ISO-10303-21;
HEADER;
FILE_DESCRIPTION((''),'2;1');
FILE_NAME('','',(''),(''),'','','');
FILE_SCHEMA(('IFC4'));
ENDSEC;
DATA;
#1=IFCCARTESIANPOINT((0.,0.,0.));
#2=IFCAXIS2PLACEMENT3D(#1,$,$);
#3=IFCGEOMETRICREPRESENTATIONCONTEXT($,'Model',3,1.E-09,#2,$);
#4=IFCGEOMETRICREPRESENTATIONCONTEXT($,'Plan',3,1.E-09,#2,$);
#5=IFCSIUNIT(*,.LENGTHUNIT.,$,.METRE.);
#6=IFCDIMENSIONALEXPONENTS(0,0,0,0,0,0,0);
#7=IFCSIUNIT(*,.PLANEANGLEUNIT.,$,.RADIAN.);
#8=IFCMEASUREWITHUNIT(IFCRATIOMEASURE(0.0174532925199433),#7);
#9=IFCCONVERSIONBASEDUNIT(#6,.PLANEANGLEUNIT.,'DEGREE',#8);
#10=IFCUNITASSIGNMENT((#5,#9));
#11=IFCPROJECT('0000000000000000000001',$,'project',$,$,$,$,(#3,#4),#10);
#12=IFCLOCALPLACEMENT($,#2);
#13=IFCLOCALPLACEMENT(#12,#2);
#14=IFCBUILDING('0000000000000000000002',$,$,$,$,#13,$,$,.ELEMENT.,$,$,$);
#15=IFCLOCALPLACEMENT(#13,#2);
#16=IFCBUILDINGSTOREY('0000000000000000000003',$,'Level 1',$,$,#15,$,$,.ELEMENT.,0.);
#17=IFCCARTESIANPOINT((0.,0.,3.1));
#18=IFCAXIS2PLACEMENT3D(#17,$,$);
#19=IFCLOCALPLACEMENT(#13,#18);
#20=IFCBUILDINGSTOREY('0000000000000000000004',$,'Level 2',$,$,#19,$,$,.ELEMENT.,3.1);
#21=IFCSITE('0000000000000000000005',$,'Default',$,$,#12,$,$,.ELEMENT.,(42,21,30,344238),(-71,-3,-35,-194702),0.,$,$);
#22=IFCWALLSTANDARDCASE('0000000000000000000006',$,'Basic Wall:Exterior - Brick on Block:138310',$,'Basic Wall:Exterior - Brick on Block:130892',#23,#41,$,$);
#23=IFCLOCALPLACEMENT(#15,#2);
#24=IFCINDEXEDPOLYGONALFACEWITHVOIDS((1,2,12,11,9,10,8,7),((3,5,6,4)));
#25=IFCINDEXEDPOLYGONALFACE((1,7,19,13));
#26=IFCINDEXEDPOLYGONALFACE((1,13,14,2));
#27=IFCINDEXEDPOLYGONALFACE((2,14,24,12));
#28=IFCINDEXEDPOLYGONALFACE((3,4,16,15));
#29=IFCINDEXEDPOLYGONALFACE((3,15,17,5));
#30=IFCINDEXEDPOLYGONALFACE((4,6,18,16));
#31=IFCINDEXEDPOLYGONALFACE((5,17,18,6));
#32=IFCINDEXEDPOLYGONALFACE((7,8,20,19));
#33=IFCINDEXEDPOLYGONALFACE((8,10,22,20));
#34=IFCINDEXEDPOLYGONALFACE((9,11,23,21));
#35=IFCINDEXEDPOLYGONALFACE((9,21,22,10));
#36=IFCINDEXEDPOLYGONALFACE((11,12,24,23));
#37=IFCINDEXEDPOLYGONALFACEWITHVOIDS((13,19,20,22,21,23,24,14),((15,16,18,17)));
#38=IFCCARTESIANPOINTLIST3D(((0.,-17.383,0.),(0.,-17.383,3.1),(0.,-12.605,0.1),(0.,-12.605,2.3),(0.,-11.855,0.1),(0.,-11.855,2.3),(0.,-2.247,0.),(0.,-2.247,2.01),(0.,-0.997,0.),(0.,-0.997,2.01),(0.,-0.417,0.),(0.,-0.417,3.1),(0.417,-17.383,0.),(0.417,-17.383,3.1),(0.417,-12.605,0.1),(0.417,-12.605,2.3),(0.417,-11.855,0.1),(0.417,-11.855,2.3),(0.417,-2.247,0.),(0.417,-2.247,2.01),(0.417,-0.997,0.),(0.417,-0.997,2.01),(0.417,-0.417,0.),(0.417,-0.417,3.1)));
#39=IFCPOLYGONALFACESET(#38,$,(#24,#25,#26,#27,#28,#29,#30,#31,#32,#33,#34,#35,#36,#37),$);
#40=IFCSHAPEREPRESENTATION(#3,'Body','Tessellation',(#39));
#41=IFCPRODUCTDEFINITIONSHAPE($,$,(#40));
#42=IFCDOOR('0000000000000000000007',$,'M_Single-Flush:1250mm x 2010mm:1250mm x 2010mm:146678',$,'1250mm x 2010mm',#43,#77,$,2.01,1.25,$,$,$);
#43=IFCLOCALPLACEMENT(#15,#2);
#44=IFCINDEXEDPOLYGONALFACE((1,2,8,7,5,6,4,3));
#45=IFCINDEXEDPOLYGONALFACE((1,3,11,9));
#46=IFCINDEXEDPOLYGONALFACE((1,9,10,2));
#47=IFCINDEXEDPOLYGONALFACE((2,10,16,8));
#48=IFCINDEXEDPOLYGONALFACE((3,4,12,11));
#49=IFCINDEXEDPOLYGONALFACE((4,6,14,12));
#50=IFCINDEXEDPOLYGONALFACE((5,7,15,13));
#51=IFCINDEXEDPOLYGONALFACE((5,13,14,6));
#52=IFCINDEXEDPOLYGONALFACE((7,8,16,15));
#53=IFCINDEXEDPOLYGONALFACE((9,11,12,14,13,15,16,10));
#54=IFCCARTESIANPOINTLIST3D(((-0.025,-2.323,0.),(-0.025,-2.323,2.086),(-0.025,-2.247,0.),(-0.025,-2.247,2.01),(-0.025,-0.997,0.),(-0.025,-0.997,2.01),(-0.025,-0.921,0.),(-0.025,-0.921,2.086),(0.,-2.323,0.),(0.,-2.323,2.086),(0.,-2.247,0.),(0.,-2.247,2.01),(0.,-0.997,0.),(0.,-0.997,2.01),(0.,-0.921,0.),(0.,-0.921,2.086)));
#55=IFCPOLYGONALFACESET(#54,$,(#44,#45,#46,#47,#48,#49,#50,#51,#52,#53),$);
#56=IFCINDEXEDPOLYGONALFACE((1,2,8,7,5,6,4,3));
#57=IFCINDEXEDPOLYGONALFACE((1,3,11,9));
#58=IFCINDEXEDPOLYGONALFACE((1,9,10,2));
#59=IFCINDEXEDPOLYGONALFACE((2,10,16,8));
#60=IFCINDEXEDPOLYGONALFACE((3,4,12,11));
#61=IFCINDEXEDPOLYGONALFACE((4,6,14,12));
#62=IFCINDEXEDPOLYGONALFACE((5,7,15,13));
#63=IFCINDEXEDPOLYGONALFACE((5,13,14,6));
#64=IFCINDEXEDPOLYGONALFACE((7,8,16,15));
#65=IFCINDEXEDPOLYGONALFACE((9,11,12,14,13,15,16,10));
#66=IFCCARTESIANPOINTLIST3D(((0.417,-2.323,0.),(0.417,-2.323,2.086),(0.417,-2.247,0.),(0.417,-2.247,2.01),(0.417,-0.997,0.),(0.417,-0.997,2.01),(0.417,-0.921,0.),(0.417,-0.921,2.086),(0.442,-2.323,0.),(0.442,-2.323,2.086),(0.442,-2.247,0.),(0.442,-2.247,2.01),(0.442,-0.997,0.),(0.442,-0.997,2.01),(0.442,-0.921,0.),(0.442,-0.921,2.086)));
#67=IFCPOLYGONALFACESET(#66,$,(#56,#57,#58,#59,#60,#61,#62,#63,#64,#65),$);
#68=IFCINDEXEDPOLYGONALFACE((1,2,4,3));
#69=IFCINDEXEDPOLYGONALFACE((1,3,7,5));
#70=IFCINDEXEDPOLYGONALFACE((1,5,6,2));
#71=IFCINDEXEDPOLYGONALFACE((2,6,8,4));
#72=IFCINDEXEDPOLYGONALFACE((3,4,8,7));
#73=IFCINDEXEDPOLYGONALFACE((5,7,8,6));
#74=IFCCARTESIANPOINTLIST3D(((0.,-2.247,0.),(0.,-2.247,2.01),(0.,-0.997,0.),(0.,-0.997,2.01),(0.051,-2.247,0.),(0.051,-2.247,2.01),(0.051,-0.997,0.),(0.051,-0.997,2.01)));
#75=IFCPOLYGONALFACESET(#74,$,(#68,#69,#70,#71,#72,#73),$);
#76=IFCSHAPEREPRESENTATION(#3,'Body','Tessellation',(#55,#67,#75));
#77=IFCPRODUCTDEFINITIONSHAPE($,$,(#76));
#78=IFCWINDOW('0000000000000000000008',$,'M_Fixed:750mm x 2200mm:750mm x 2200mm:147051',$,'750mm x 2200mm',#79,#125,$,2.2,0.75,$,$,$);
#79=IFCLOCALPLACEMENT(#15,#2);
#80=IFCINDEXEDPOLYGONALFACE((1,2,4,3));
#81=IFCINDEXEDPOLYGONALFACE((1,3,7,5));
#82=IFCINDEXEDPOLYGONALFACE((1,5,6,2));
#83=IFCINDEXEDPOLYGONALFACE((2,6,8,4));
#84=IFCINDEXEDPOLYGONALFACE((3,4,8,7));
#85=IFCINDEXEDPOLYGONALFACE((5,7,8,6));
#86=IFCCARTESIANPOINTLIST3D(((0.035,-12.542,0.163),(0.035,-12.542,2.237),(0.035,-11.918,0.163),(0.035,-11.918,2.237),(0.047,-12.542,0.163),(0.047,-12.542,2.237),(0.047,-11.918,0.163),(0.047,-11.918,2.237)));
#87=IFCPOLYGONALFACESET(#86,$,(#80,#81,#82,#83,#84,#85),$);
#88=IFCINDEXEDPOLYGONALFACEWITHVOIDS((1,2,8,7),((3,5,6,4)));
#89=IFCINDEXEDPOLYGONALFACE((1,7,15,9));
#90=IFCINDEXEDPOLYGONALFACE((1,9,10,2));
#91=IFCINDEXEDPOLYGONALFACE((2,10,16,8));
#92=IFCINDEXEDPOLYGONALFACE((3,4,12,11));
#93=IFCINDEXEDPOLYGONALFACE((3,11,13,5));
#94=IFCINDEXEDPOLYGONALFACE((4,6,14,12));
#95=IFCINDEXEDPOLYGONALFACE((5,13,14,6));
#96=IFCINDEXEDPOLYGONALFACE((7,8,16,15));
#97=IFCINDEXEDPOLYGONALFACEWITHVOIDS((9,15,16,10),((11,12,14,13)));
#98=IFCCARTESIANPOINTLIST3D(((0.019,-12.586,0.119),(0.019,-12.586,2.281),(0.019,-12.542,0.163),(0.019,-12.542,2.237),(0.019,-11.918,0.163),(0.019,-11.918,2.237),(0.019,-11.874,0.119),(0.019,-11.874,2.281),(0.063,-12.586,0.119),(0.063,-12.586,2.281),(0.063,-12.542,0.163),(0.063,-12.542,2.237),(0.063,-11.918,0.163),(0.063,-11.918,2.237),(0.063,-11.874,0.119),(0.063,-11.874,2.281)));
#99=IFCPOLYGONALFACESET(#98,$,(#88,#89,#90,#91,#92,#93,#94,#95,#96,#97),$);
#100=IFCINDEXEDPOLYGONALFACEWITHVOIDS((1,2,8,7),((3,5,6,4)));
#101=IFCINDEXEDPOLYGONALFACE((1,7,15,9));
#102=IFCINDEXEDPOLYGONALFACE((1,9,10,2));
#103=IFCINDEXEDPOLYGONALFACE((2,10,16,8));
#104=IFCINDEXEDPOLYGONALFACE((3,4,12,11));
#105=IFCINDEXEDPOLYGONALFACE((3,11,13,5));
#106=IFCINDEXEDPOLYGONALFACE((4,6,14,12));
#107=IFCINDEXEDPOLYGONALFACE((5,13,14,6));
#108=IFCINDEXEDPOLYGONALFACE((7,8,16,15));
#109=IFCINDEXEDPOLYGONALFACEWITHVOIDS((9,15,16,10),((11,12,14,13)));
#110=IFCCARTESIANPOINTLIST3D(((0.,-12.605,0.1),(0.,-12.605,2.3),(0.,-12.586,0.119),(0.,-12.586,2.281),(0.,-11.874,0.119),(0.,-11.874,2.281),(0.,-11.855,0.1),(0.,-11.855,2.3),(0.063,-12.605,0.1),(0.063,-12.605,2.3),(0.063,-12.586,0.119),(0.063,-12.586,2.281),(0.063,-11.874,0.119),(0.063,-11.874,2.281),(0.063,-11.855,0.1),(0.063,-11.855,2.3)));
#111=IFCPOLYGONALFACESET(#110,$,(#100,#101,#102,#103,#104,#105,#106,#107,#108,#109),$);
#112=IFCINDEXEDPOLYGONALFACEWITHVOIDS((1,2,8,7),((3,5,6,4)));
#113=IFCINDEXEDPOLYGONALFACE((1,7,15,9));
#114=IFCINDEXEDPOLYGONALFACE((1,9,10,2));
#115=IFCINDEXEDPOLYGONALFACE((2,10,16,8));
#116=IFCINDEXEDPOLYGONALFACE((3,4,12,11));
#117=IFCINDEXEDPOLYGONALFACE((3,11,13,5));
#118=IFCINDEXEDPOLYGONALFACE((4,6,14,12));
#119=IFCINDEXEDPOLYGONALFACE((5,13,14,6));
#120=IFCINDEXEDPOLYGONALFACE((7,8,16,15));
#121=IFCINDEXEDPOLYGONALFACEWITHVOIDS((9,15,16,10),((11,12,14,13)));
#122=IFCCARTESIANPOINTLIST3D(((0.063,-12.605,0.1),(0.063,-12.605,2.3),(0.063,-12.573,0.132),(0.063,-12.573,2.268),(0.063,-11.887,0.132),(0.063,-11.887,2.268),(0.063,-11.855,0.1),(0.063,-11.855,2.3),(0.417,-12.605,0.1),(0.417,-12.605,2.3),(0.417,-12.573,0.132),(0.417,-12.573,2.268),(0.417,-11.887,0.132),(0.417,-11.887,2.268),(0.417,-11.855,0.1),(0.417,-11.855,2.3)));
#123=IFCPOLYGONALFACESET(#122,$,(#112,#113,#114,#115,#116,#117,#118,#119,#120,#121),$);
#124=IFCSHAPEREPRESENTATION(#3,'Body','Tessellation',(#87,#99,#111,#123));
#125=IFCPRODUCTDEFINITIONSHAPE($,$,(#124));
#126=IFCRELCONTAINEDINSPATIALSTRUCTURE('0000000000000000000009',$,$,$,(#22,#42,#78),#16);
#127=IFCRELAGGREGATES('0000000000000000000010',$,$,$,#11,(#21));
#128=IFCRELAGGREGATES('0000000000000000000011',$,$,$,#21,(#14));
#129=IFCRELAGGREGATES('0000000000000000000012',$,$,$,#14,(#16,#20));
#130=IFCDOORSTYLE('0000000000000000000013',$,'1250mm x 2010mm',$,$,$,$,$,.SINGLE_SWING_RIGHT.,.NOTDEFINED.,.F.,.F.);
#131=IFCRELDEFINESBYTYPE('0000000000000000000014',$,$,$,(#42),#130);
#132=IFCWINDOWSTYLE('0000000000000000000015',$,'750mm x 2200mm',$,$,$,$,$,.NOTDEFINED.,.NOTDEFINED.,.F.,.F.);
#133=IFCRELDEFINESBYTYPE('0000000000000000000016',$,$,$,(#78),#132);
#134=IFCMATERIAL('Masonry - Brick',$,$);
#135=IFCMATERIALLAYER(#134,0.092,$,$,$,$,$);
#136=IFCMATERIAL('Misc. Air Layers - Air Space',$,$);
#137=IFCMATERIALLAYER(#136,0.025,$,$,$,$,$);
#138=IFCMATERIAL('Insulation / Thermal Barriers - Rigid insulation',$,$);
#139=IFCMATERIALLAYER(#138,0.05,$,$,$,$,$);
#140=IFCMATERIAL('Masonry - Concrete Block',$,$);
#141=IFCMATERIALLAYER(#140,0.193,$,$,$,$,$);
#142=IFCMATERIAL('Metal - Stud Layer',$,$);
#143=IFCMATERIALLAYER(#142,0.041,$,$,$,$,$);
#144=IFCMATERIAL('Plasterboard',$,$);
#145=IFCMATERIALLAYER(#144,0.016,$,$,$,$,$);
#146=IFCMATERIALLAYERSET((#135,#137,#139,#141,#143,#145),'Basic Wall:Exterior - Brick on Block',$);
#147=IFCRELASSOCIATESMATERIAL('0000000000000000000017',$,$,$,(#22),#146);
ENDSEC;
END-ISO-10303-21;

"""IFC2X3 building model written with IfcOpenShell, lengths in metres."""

from ifc_helpers import new_model, entity, si_unit, converted_unit, frame, frame_2d, origin, origin_2d_with_axis, place, context, project, spatial, polyline, rectangle, outline, extrude, source, transform, mapped, material, layer, layer_set, layer_usage, type_object, type_shapes, element, fill, save


model = new_model("IFC2X3")

# Units and contexts
model_context = context("Model", 3, precision=1e-09, world=origin())
plan_context = context("Plan", 3, precision=1e-09, world=origin())
ifc_project = project(units=[si_unit("LENGTHUNIT", "METRE"), converted_unit("PLANEANGLEUNIT", "DEGREE", entity("IfcRatioMeasure", 0.0174532925199433), si_unit("PLANEANGLEUNIT", "RADIAN"), dimensions=[0, 0, 0, 0, 0, 0, 0])], contexts=[model_context, plan_context])

# Site, building, storey
site_placement = place(None, origin())
site = spatial("IfcSite", under=ifc_project, at=site_placement, Name="Default", CompositionType="ELEMENT", RefLatitude=(42, 21, 30, 344238), RefLongitude=(-71, -3, -35, -194702), RefElevation=0.0)
building_placement = place(site_placement, origin())
building = spatial("IfcBuilding", under=site, at=building_placement, CompositionType="ELEMENT")
storey_1_placement = place(building_placement, origin())
storey_1 = spatial("IfcBuildingStorey", under=building, at=storey_1_placement, Name="Level 1", CompositionType="ELEMENT", Elevation=0.0)

# Shared definitions
ifc_material_1 = material(Name="Masonry - Brick")
ifc_layer_1 = layer(ifc_material_1, 0.092)
ifc_material_2 = material(Name="Misc. Air Layers - Air Space")
ifc_layer_2 = layer(ifc_material_2, 0.025)
ifc_material_3 = material(Name="Insulation / Thermal Barriers - Rigid insulation")
ifc_layer_3 = layer(ifc_material_3, 0.05)
ifc_material_4 = material(Name="Masonry - Concrete Block")
ifc_layer_4 = layer(ifc_material_4, 0.193)
ifc_material_5 = material(Name="Metal - Stud Layer")
ifc_layer_5 = layer(ifc_material_5, 0.041)
ifc_material_6 = material(Name="Plasterboard")
ifc_layer_6 = layer(ifc_material_6, 0.016)
ifc_layer_set_1 = layer_set([ifc_layer_1, ifc_layer_2, ifc_layer_3, ifc_layer_4, ifc_layer_5, ifc_layer_6], Name="Basic Wall:Exterior - Brick on Block")
ifc_layer_usage_1 = layer_usage(ifc_layer_set_1, "AXIS2", "NEGATIVE", 0.2085)

# Wall, openings, door, window
wall_1_placement = place(storey_1_placement, frame((0.2085, -17.383, 0.0), z_axis=(0.0, 0.0, 1.0), x_axis=(0.0, 1.0, 0.0)))
wall_1 = element("IfcWallStandardCase", 1, at=wall_1_placement, inside=storey_1, material=ifc_layer_usage_1, Name="Basic Wall:Exterior - Brick on Block:138310", ObjectType="Basic Wall:Exterior - Brick on Block:130892", context=model_context, shape_type="SweptSolid", body=[
    extrude(rectangle(XDim=16.966, YDim=0.417, at=frame_2d((8.483, 0.0), x_axis=(-1.0, 0.0))), origin(), (0.0, 0.0, 1.0), 3.1),
])
opening_1_placement = place(wall_1_placement, frame((15.136, -0.2085, 0.0)))
opening_1 = element("IfcOpeningElement", 2, at=opening_1_placement, cuts=wall_1, ObjectType="Opening", context=model_context, shape_type="SweptSolid", body=[
    extrude(rectangle(XDim=1.25, YDim=2.01, at=frame_2d((1.005, 0.625), x_axis=(0.0, 1.0))), frame((0.0, 0.0, 0.0), z_axis=(0.0, 1.0, 0.0), x_axis=(0.0, 0.0, 1.0)), (0.0, 0.0, 1.0), 0.417),
])
opening_2_placement = place(wall_1_placement, frame((4.778, -0.2085, 0.1)))
opening_2 = element("IfcOpeningElement", 3, at=opening_2_placement, cuts=wall_1, ObjectType="Opening", context=model_context, shape_type="SweptSolid", body=[
    extrude(rectangle(XDim=2.2, YDim=0.75, at=frame_2d((1.1, 0.375), x_axis=(1.0, 0.0))), frame((0.0, 0.0, 0.0), z_axis=(0.0, 1.0, 0.0), x_axis=(0.0, 0.0, 1.0)), (0.0, 0.0, 1.0), 0.417),
])
door_style_1 = type_object("IfcDoorStyle", Name="1250mm x 2010mm", ConstructionType="NOTDEFINED", OperationType="SINGLE_SWING_RIGHT", ParameterTakesPrecedence=False, Sizeable=False)
shared_shape_1 = source(origin(), model_context, "Body", "SweptSolid", [
    extrude(outline(polyline([(-0.701, -1.062), (0.701, -1.062), (0.701, 1.024), (0.625, 1.024), (0.625, -0.986), (-0.625, -0.986), (-0.625, 1.024), (-0.701, 1.024), (-0.701, -1.062)])), frame((0.625, 0.417, 1.024), z_axis=(0.0, 1.0, 0.0), x_axis=(1.0, 0.0, 0.0)), (0.0, 0.0, 1.0), 0.025),
    extrude(outline(polyline([(-1.062, -0.701), (1.024, -0.701), (1.024, -0.625), (-0.986, -0.625), (-0.986, 0.625), (1.024, 0.625), (1.024, 0.701), (-1.062, 0.701), (-1.062, -0.701)])), frame((0.625, -0.025, 1.024), z_axis=(0.0, 1.0, 0.0), x_axis=(0.0, 0.0, -1.0)), (0.0, 0.0, 1.0), 0.025),
    extrude(rectangle(XDim=0.051, YDim=1.25, at=origin_2d_with_axis()), frame((0.625, 0.3915, 0.0), z_axis=(0.0, 0.0, 1.0), x_axis=(0.0, 1.0, 0.0)), (0.0, 0.0, 1.0), 2.01),
])
type_shapes(door_style_1, [shared_shape_1])
door_1_placement = place(opening_1_placement, origin())
door_1 = element("IfcDoor", 4, at=door_1_placement, inside=storey_1, type_object=door_style_1, Name="M_Single-Flush:1250mm x 2010mm:1250mm x 2010mm:146678", ObjectType="1250mm x 2010mm", OverallHeight=2.01, OverallWidth=1.25, context=model_context, shape_type="MappedRepresentation", body=[
    mapped(shared_shape_1, transform((0.0, 0.0, 0.0), scale=1.0)),
])
fill(opening_1, door_1)
window_style_1 = type_object("IfcWindowStyle", Name="750mm x 2200mm", ConstructionType="NOTDEFINED", OperationType="NOTDEFINED", ParameterTakesPrecedence=False, Sizeable=False)
shared_shape_2 = source(origin(), model_context, "Body", "SweptSolid", [
    extrude(rectangle(XDim=0.012, YDim=0.624, at=origin_2d_with_axis()), frame((0.375, 0.376, 0.063), z_axis=(0.0, 0.0, 1.0), x_axis=(0.0, -1.0, 0.0)), (0.0, 0.0, 1.0), 2.074),
    extrude(outline(polyline([(-0.356, -1.081), (0.356, -1.081), (0.356, 1.081), (-0.356, 1.081), (-0.356, -1.081)]), holes=[polyline([(-0.312, -1.037), (-0.312, 1.037), (0.312, 1.037), (0.312, -1.037), (-0.312, -1.037)])]), frame((0.375, 0.354, 1.1), z_axis=(0.0, 1.0, 0.0), x_axis=(1.0, 0.0, 0.0)), (0.0, 0.0, 1.0), 0.044),
    extrude(outline(polyline([(-0.375, -1.1), (0.375, -1.1), (0.375, 1.1), (-0.375, 1.1), (-0.375, -1.1)]), holes=[polyline([(-0.356, -1.081), (-0.356, 1.081), (0.356, 1.081), (0.356, -1.081), (-0.356, -1.081)])]), frame((0.375, 0.354, 1.1), z_axis=(0.0, 1.0, 0.0), x_axis=(1.0, 0.0, 0.0)), (0.0, 0.0, 1.0), 0.063),
    extrude(outline(polyline([(-0.375, -1.1), (0.375, -1.1), (0.375, 1.1), (-0.375, 1.1), (-0.375, -1.1)]), holes=[polyline([(-0.343, -1.068), (-0.343, 1.068), (0.343, 1.068), (0.343, -1.068), (-0.343, -1.068)])]), frame((0.375, 0.0, 1.1), z_axis=(0.0, 1.0, 0.0), x_axis=(1.0, 0.0, 0.0)), (0.0, 0.0, 1.0), 0.354),
])
type_shapes(window_style_1, [shared_shape_2])
window_1_placement = place(opening_2_placement, origin())
window_1 = element("IfcWindow", 5, at=window_1_placement, inside=storey_1, type_object=window_style_1, Name="M_Fixed:750mm x 2200mm:750mm x 2200mm:147051", ObjectType="750mm x 2200mm", OverallHeight=2.2, OverallWidth=0.75, context=model_context, shape_type="MappedRepresentation", body=[
    mapped(shared_shape_2, transform((0.0, 0.0, 0.0), scale=1.0)),
])
fill(opening_2, window_1)

# Shared definitions
storey_2_placement = place(building_placement, frame((0.0, 0.0, 3.1)))
storey_2 = spatial("IfcBuildingStorey", under=building, at=storey_2_placement, Name="Level 2", CompositionType="ELEMENT", Elevation=3.1)

save(model, "model.ifc")
